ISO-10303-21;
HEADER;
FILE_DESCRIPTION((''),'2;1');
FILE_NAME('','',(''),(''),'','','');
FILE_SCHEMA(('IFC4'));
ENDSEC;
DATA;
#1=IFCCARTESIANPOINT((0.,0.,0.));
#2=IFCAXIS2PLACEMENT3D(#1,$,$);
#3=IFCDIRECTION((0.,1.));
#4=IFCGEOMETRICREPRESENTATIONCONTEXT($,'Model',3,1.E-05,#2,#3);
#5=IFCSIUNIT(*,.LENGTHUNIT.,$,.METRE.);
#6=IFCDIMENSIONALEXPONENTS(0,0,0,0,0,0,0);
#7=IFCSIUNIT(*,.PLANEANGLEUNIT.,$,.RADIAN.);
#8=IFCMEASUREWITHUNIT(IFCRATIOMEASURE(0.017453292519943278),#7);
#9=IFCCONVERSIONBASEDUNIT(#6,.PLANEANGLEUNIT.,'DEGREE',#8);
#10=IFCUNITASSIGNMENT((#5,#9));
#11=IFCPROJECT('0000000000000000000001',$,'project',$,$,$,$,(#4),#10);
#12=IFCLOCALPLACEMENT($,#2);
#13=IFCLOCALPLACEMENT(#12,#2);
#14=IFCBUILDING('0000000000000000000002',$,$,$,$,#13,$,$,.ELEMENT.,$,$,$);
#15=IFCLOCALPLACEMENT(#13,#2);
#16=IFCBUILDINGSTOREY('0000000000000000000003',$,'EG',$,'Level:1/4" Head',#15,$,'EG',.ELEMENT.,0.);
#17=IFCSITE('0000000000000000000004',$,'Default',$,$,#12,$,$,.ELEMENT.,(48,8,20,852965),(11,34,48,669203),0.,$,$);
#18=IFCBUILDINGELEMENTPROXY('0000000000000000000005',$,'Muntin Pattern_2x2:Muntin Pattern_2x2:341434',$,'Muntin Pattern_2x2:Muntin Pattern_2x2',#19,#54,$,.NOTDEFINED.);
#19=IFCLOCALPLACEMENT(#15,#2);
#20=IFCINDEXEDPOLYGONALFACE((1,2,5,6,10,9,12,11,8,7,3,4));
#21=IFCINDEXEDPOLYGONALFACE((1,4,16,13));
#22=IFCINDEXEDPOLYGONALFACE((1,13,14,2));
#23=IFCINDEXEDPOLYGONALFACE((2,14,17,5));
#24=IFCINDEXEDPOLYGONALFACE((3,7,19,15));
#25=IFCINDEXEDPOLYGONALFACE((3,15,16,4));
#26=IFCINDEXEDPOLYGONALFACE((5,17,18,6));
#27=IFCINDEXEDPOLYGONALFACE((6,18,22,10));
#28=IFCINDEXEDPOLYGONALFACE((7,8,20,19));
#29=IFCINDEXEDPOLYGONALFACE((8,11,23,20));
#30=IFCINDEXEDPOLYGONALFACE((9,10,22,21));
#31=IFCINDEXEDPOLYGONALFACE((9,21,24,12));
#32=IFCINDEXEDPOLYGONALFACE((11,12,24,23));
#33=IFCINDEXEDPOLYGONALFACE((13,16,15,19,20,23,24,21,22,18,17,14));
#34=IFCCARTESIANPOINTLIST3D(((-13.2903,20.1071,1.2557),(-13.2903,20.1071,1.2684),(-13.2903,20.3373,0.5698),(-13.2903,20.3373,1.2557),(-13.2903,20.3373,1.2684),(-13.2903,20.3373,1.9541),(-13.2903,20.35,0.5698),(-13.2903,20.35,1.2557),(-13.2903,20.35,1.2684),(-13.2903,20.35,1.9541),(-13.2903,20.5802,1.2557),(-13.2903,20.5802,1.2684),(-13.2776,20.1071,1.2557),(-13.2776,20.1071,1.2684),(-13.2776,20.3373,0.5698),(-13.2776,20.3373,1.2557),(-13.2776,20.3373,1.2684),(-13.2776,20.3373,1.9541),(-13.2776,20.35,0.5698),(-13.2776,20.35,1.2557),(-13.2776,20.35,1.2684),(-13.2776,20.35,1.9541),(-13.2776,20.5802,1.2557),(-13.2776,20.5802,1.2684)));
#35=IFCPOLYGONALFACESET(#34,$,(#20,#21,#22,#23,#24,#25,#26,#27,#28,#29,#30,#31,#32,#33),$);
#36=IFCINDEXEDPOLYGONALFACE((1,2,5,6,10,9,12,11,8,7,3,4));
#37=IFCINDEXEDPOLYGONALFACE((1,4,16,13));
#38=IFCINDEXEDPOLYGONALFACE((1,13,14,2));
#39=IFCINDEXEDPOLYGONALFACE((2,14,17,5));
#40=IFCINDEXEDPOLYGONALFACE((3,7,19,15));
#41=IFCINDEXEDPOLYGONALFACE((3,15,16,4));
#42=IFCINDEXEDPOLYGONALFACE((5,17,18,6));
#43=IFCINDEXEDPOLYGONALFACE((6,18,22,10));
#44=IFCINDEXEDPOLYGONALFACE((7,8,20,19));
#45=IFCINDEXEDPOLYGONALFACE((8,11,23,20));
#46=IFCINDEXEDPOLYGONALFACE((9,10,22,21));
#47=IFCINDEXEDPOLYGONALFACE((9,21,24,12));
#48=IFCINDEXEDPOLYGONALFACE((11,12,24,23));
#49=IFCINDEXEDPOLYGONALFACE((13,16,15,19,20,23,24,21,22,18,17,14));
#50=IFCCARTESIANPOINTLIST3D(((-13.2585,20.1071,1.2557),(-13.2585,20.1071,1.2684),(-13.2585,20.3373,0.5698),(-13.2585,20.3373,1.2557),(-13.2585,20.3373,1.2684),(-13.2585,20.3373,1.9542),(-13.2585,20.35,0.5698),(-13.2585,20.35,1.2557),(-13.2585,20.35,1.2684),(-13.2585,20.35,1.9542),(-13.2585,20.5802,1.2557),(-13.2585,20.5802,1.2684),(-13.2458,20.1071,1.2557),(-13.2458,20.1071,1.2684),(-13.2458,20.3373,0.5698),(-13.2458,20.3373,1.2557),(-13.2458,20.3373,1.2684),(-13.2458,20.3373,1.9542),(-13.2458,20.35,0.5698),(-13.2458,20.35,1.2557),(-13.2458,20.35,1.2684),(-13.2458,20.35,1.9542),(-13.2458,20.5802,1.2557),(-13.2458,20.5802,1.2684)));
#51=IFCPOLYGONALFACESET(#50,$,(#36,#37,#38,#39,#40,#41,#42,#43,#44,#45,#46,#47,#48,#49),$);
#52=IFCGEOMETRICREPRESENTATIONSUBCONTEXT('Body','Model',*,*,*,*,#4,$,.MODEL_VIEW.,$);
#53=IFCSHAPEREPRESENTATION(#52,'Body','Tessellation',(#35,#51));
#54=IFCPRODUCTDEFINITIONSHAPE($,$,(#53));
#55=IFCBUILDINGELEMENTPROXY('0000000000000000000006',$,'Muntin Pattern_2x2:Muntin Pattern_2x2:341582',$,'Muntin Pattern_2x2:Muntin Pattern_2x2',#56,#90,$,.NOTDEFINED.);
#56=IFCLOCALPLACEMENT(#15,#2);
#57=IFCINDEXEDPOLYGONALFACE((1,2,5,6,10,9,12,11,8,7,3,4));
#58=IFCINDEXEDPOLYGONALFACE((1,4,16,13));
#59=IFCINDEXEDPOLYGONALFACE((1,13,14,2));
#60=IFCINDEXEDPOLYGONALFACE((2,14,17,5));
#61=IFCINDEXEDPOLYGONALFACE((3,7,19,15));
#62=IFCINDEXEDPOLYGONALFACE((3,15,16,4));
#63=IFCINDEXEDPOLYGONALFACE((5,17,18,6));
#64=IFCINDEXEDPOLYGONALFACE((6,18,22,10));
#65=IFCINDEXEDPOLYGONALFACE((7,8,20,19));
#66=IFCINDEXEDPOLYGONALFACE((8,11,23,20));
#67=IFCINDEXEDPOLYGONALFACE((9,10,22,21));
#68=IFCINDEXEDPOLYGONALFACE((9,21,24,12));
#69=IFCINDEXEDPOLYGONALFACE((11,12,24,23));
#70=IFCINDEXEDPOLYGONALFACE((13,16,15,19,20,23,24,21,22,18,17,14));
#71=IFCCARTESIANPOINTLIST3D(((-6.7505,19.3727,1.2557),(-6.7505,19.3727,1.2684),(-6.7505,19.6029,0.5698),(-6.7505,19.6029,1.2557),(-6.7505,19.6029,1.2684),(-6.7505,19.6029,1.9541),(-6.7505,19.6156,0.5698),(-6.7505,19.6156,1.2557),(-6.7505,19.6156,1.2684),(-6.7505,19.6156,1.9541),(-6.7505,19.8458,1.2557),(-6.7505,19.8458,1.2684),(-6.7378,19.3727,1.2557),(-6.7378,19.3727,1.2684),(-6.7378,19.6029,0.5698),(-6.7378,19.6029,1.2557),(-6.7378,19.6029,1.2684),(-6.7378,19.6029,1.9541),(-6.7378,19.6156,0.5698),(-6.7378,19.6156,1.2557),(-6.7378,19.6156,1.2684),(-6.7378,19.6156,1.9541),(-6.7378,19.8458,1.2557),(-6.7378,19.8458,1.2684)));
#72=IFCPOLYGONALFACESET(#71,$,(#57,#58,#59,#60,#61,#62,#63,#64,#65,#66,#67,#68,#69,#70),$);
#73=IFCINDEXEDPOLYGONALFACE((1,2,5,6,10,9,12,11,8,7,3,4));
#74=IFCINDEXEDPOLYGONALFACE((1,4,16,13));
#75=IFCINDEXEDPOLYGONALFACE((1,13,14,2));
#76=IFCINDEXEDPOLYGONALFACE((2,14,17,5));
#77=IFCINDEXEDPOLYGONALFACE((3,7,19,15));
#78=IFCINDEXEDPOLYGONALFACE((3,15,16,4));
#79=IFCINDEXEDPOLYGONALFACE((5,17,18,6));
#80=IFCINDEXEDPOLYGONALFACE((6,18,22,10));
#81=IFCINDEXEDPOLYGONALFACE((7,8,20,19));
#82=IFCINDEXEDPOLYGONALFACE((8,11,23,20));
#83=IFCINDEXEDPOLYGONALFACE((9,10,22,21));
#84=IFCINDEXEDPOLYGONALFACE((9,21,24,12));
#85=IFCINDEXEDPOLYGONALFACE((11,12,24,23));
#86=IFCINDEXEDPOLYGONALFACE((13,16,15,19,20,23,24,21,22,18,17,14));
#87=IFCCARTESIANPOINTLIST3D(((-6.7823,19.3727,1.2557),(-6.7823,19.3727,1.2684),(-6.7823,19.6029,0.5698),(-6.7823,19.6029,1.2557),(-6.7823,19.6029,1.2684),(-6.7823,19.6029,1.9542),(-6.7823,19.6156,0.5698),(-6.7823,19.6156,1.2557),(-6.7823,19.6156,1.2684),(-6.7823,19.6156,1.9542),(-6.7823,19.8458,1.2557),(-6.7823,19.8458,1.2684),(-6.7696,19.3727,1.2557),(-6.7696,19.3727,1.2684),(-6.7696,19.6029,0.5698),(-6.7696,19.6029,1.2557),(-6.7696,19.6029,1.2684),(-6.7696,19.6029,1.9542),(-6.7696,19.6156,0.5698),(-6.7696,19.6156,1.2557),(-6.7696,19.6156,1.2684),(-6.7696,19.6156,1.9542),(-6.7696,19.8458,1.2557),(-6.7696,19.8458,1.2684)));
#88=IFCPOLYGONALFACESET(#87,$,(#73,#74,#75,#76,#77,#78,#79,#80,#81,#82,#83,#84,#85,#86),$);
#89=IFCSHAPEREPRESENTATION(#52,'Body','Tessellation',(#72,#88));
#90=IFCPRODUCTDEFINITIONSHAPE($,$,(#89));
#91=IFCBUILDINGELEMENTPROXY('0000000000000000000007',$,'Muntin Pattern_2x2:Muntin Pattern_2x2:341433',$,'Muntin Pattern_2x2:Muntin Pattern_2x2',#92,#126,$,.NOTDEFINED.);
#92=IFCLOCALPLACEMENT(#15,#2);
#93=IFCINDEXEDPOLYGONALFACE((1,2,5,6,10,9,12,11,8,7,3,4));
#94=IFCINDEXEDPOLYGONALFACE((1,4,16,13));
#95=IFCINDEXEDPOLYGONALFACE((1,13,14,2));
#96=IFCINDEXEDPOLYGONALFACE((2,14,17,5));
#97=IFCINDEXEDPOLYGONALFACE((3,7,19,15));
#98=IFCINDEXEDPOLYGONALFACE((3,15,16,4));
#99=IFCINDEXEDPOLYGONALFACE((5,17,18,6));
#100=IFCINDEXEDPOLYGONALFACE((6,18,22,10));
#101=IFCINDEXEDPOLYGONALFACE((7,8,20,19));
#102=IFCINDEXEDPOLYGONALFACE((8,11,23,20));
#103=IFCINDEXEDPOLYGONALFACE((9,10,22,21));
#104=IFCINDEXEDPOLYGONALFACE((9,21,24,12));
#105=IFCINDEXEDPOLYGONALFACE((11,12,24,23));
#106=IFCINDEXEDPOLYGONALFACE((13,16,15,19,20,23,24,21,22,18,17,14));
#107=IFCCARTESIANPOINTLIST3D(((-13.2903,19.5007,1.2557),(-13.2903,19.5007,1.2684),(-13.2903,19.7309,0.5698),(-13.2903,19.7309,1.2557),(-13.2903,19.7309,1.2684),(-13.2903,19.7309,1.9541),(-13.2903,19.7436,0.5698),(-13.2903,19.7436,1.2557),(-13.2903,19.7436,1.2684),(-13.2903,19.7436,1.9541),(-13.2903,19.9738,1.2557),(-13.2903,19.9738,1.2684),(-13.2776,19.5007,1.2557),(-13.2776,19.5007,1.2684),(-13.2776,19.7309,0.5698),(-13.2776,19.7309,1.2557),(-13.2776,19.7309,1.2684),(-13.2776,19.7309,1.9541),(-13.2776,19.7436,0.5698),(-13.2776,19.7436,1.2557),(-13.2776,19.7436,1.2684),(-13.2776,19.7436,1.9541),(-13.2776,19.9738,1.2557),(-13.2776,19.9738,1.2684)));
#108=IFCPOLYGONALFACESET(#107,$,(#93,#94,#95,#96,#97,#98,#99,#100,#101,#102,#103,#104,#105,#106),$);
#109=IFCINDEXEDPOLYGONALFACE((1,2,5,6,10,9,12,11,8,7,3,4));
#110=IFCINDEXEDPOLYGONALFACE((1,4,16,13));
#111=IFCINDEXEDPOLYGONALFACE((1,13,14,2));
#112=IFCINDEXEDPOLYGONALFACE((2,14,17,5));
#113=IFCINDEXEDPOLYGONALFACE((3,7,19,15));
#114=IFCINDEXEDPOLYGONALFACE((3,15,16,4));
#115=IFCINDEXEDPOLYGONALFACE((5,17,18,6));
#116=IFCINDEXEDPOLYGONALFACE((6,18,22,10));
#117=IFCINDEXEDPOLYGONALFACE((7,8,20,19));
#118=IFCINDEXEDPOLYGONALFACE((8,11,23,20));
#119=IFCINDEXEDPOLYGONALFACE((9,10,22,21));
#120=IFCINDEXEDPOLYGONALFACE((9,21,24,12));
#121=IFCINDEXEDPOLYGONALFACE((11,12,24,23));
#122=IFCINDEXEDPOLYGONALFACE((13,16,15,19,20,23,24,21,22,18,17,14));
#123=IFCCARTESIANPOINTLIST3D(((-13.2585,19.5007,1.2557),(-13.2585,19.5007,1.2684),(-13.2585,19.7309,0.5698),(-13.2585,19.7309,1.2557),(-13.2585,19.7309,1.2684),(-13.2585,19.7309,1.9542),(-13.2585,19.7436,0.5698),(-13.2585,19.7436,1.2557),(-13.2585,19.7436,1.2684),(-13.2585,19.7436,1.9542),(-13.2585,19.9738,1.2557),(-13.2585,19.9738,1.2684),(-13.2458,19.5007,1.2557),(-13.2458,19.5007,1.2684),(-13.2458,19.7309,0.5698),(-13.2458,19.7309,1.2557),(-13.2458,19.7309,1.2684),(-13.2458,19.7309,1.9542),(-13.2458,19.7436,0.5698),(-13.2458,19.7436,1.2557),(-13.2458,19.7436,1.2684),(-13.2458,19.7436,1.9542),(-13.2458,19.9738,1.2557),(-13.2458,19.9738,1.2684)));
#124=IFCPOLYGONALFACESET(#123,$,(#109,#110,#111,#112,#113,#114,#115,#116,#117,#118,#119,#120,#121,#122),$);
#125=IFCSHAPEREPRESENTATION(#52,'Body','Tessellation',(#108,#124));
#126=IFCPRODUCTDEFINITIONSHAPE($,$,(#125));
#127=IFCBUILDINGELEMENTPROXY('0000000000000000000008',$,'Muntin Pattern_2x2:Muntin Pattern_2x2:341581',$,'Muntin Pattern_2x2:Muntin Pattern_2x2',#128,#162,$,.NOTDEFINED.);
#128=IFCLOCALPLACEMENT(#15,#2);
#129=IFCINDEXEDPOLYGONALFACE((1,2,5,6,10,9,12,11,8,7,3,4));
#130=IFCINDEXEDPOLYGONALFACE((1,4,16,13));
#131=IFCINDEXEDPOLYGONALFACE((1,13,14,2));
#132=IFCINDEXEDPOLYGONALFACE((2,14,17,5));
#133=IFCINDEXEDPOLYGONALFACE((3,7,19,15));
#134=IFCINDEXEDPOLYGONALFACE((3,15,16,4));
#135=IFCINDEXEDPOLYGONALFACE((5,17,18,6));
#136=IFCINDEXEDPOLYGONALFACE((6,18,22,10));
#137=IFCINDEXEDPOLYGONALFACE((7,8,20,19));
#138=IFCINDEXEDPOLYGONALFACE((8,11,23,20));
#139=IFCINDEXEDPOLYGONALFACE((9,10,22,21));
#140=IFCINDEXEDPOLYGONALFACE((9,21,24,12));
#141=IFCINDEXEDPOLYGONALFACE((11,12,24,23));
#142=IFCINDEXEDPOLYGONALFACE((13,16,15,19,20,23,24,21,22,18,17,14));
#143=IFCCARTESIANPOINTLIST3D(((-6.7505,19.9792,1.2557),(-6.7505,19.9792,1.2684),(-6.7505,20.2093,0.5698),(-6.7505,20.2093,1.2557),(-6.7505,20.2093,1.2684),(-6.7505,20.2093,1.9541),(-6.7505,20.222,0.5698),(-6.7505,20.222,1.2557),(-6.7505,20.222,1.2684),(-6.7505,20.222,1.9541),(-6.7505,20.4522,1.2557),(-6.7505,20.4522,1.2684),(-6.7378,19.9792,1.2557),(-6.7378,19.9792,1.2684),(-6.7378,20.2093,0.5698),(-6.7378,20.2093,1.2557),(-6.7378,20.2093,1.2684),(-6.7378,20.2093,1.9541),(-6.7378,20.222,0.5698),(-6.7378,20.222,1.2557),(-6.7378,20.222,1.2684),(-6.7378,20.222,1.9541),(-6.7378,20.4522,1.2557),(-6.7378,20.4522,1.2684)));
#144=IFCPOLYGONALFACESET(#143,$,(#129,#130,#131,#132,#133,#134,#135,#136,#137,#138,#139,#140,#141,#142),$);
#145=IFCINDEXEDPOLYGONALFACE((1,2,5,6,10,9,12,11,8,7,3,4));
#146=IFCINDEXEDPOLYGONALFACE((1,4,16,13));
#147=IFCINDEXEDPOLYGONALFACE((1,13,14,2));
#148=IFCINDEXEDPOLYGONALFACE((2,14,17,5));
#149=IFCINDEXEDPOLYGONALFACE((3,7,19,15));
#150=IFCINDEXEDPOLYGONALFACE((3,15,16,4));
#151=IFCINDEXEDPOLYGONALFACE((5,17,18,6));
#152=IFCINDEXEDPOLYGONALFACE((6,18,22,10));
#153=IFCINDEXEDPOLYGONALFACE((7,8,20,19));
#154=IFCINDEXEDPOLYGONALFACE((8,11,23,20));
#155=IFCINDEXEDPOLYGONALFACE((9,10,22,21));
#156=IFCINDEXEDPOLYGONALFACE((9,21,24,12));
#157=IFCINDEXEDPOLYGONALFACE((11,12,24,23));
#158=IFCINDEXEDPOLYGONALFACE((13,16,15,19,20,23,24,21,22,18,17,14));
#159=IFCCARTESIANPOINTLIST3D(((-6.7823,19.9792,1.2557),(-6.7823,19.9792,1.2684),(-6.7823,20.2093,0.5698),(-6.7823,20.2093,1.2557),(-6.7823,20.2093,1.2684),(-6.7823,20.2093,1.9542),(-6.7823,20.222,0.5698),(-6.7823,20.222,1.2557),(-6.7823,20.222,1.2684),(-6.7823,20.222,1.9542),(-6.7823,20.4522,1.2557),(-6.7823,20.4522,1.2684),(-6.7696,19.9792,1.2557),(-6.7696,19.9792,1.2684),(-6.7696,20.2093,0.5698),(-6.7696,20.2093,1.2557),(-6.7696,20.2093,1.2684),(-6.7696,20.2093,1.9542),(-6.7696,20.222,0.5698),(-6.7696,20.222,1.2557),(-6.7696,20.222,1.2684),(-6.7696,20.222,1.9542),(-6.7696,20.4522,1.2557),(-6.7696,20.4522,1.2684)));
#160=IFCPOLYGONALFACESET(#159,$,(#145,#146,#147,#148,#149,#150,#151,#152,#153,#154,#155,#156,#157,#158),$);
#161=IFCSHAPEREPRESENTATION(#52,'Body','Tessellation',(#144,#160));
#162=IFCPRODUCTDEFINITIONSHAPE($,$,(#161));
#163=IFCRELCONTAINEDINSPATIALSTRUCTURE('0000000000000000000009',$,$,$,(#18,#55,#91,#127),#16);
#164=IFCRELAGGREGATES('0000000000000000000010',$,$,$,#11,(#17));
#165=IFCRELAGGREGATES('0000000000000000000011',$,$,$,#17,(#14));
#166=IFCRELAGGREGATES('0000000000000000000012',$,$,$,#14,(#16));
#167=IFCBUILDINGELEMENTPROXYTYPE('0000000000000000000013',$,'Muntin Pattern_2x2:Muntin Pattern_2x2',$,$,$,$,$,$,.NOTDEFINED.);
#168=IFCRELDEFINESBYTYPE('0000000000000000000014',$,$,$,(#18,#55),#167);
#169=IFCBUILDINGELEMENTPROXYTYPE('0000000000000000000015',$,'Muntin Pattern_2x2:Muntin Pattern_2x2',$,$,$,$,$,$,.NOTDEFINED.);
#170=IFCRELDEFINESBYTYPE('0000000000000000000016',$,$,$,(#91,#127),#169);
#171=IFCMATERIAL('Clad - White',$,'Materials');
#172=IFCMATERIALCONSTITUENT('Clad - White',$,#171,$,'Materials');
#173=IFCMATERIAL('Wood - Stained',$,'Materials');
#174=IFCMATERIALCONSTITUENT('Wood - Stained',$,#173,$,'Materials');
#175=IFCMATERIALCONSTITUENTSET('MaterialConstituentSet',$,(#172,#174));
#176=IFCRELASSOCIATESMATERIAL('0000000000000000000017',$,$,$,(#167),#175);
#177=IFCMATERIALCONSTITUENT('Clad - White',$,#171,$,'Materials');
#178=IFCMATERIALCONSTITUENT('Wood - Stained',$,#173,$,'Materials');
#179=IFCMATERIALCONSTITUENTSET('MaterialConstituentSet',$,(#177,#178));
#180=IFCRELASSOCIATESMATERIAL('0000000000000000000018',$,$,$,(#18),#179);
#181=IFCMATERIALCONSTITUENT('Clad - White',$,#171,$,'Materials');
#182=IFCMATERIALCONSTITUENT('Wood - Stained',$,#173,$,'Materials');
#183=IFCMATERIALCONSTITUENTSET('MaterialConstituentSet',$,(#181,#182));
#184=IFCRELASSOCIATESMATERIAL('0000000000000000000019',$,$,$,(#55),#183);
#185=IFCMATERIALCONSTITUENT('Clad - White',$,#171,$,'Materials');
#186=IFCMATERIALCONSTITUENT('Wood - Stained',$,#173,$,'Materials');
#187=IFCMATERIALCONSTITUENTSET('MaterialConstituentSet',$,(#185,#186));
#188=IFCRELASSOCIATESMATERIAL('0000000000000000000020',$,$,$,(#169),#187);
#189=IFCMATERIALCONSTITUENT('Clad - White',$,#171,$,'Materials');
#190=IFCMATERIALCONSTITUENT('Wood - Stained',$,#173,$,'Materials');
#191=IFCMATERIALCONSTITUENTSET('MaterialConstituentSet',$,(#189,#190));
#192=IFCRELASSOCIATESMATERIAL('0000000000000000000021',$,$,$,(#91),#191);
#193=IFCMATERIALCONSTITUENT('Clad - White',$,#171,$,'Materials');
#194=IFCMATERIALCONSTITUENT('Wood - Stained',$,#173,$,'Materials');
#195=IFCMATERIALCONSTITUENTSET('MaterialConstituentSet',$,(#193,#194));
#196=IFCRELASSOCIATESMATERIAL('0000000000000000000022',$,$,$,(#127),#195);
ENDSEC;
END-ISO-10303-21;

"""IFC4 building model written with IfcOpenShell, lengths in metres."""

from ifc_helpers import new_model, entity, si_unit, converted_unit, direction, frame, origin, place, context, subcontext, project, spatial, indexed_curve, outline, extrude, source, transform, mapped, material, constituent, constituent_set, type_object, type_shapes, element, save


model = new_model("IFC4")

# Units and contexts
model_context = context("Model", 3, precision=1e-05, world=origin(), true_north=direction((0.0, 1.0)))
body_context = subcontext(model_context, "Body", "Model", "MODEL_VIEW")
ifc_project = project(units=[si_unit("LENGTHUNIT", "METRE"), converted_unit("PLANEANGLEUNIT", "DEGREE", entity("IfcRatioMeasure", 0.017453292519943278), si_unit("PLANEANGLEUNIT", "RADIAN"), dimensions=[0, 0, 0, 0, 0, 0, 0])], contexts=[model_context])

# Site, building, storey
site_placement = place(None, origin())
site = spatial("IfcSite", under=ifc_project, at=site_placement, Name="Default", CompositionType="ELEMENT", RefLatitude=(48, 8, 20, 852965), RefLongitude=(11, 34, 48, 669203), RefElevation=0.0)
building_placement = place(site_placement, origin())
building = spatial("IfcBuilding", under=site, at=building_placement, CompositionType="ELEMENT")
storey_placement = place(building_placement, origin())
storey = spatial("IfcBuildingStorey", under=building, at=storey_placement, Name="EG", ObjectType="Level:1/4\" Head", LongName="EG", CompositionType="ELEMENT", Elevation=0.0)

# Building element proxies
ifc_material_1 = material(Name="Clad - White", Category="Materials")
ifc_material_2 = material(Name="Wood - Stained", Category="Materials")
ifc_constituent_1 = constituent(ifc_material_1, Name="Clad - White", Category="Materials")
ifc_constituent_2 = constituent(ifc_material_2, Name="Wood - Stained", Category="Materials")
ifc_constituent_set_1 = constituent_set(constituents=[ifc_constituent_1, ifc_constituent_2], Name="MaterialConstituentSet")
building_element_proxy_type_1 = type_object("IfcBuildingElementProxyType", Name="Muntin Pattern_2x2:Muntin Pattern_2x2", PredefinedType="NOTDEFINED", material=ifc_constituent_set_1)
shared_shape_1 = source(origin(), body_context, "Body", "SweptSolid", [
    extrude(outline(indexed_curve([(0.0064, -0.0064), (0.6921, -0.0064), (0.6921, 0.0063), (0.0064, 0.0063), (0.0064, 0.2365), (-0.0063, 0.2365), (-0.0063, 0.0063), (-0.6922, 0.0063), (-0.6922, -0.0064), (-0.0063, -0.0064), (-0.0063, -0.2365), (0.0064, -0.2365), (0.0064, -0.0064)], self_intersect=False)), frame((0.0, -0.0222, 0.6921), z_axis=(0.0, 1.0, 0.0), x_axis=(0.0, 0.0, 1.0)), (0.0, 0.0, 1.0), 0.0127),
    extrude(outline(indexed_curve([(0.0064, -0.0064), (0.6922, -0.0064), (0.6922, 0.0063), (0.0064, 0.0063), (0.0064, 0.2365), (-0.0063, 0.2365), (-0.0063, 0.0063), (-0.6922, 0.0063), (-0.6922, -0.0064), (-0.0063, -0.0064), (-0.0063, -0.2365), (0.0064, -0.2365), (0.0064, -0.0064)], self_intersect=False)), frame((0.0, 0.0095, 0.6922), z_axis=(0.0, 1.0, 0.0), x_axis=(0.0, 0.0, 1.0)), (0.0, 0.0, 1.0), 0.0127),
])
type_shapes(building_element_proxy_type_1, [shared_shape_1])
ifc_constituent_3 = constituent(ifc_material_1, Name="Clad - White", Category="Materials")
ifc_constituent_4 = constituent(ifc_material_2, Name="Wood - Stained", Category="Materials")
ifc_constituent_set_2 = constituent_set(constituents=[ifc_constituent_3, ifc_constituent_4], Name="MaterialConstituentSet")
proxy_1_placement = place(storey_placement, frame((-13.2681, 20.3437, 0.5699), z_axis=(0.0, 0.0, 1.0), x_axis=(0.0, -1.0, 0.0)))
element("IfcBuildingElementProxy", 1, at=proxy_1_placement, inside=storey, type_object=building_element_proxy_type_1, material=ifc_constituent_set_2, Name="Muntin Pattern_2x2:Muntin Pattern_2x2:341434", ObjectType="Muntin Pattern_2x2:Muntin Pattern_2x2", PredefinedType="NOTDEFINED", context=body_context, shape_type="MappedRepresentation", body=[
    mapped(shared_shape_1, transform((0.0, 0.0, 0.0), scale=1.0)),
])
ifc_constituent_5 = constituent(ifc_material_1, Name="Clad - White", Category="Materials")
ifc_constituent_6 = constituent(ifc_material_2, Name="Wood - Stained", Category="Materials")
ifc_constituent_set_3 = constituent_set(constituents=[ifc_constituent_5, ifc_constituent_6], Name="MaterialConstituentSet")
proxy_2_placement = place(storey_placement, frame((-6.7601, 19.6093, 0.5699), z_axis=(0.0, 0.0, 1.0), x_axis=(0.0, 1.0, 0.0)))
element("IfcBuildingElementProxy", 2, at=proxy_2_placement, inside=storey, type_object=building_element_proxy_type_1, material=ifc_constituent_set_3, Name="Muntin Pattern_2x2:Muntin Pattern_2x2:341582", ObjectType="Muntin Pattern_2x2:Muntin Pattern_2x2", PredefinedType="NOTDEFINED", context=body_context, shape_type="MappedRepresentation", body=[
    mapped(shared_shape_1, transform((0.0, 0.0, 0.0), scale=1.0)),
])
ifc_constituent_7 = constituent(ifc_material_1, Name="Clad - White", Category="Materials")
ifc_constituent_8 = constituent(ifc_material_2, Name="Wood - Stained", Category="Materials")
ifc_constituent_set_4 = constituent_set(constituents=[ifc_constituent_7, ifc_constituent_8], Name="MaterialConstituentSet")
ifc_constituent_9 = constituent(ifc_material_1, Name="Clad - White", Category="Materials")
ifc_constituent_10 = constituent(ifc_material_2, Name="Wood - Stained", Category="Materials")
ifc_constituent_set_5 = constituent_set(constituents=[ifc_constituent_9, ifc_constituent_10], Name="MaterialConstituentSet")
building_element_proxy_type_2 = type_object("IfcBuildingElementProxyType", Name="Muntin Pattern_2x2:Muntin Pattern_2x2", PredefinedType="NOTDEFINED", material=ifc_constituent_set_5)
shared_shape_2 = source(origin(), body_context, "Body", "SweptSolid", [
    extrude(outline(indexed_curve([(0.0064, -0.0064), (0.6921, -0.0064), (0.6921, 0.0063), (0.0064, 0.0063), (0.0064, 0.2365), (-0.0063, 0.2365), (-0.0063, 0.0063), (-0.6922, 0.0063), (-0.6922, -0.0064), (-0.0063, -0.0064), (-0.0063, -0.2365), (0.0064, -0.2365), (0.0064, -0.0064)], self_intersect=False)), frame((0.0, 0.0095, 0.6921), z_axis=(0.0, 1.0, 0.0), x_axis=(0.0, 0.0, 1.0)), (0.0, 0.0, 1.0), 0.0127),
    extrude(outline(indexed_curve([(0.0064, -0.0064), (0.6922, -0.0064), (0.6922, 0.0063), (0.0064, 0.0063), (0.0064, 0.2365), (-0.0063, 0.2365), (-0.0063, 0.0063), (-0.6922, 0.0063), (-0.6922, -0.0064), (-0.0063, -0.0064), (-0.0063, -0.2365), (0.0064, -0.2365), (0.0064, -0.0064)], self_intersect=False)), frame((0.0, -0.0222, 0.6922), z_axis=(0.0, 1.0, 0.0), x_axis=(0.0, 0.0, 1.0)), (0.0, 0.0, 1.0), 0.0127),
])
type_shapes(building_element_proxy_type_2, [shared_shape_2])
proxy_3_placement = place(storey_placement, frame((-13.2681, 19.7372, 0.5699), z_axis=(0.0, 0.0, 1.0), x_axis=(0.0, 1.0, 0.0)))
element("IfcBuildingElementProxy", 3, at=proxy_3_placement, inside=storey, type_object=building_element_proxy_type_2, material=ifc_constituent_set_4, Name="Muntin Pattern_2x2:Muntin Pattern_2x2:341433", ObjectType="Muntin Pattern_2x2:Muntin Pattern_2x2", PredefinedType="NOTDEFINED", context=body_context, shape_type="MappedRepresentation", body=[
    mapped(shared_shape_2, transform((0.0, 0.0, 0.0), scale=1.0)),
])
ifc_constituent_11 = constituent(ifc_material_1, Name="Clad - White", Category="Materials")
ifc_constituent_12 = constituent(ifc_material_2, Name="Wood - Stained", Category="Materials")
ifc_constituent_set_6 = constituent_set(constituents=[ifc_constituent_11, ifc_constituent_12], Name="MaterialConstituentSet")
proxy_4_placement = place(storey_placement, frame((-6.7601, 20.2157, 0.5699), z_axis=(0.0, 0.0, 1.0), x_axis=(0.0, -1.0, 0.0)))
element("IfcBuildingElementProxy", 4, at=proxy_4_placement, inside=storey, type_object=building_element_proxy_type_2, material=ifc_constituent_set_6, Name="Muntin Pattern_2x2:Muntin Pattern_2x2:341581", ObjectType="Muntin Pattern_2x2:Muntin Pattern_2x2", PredefinedType="NOTDEFINED", context=body_context, shape_type="MappedRepresentation", body=[
    mapped(shared_shape_2, transform((0.0, 0.0, 0.0), scale=1.0)),
])

save(model, "model.ifc")
